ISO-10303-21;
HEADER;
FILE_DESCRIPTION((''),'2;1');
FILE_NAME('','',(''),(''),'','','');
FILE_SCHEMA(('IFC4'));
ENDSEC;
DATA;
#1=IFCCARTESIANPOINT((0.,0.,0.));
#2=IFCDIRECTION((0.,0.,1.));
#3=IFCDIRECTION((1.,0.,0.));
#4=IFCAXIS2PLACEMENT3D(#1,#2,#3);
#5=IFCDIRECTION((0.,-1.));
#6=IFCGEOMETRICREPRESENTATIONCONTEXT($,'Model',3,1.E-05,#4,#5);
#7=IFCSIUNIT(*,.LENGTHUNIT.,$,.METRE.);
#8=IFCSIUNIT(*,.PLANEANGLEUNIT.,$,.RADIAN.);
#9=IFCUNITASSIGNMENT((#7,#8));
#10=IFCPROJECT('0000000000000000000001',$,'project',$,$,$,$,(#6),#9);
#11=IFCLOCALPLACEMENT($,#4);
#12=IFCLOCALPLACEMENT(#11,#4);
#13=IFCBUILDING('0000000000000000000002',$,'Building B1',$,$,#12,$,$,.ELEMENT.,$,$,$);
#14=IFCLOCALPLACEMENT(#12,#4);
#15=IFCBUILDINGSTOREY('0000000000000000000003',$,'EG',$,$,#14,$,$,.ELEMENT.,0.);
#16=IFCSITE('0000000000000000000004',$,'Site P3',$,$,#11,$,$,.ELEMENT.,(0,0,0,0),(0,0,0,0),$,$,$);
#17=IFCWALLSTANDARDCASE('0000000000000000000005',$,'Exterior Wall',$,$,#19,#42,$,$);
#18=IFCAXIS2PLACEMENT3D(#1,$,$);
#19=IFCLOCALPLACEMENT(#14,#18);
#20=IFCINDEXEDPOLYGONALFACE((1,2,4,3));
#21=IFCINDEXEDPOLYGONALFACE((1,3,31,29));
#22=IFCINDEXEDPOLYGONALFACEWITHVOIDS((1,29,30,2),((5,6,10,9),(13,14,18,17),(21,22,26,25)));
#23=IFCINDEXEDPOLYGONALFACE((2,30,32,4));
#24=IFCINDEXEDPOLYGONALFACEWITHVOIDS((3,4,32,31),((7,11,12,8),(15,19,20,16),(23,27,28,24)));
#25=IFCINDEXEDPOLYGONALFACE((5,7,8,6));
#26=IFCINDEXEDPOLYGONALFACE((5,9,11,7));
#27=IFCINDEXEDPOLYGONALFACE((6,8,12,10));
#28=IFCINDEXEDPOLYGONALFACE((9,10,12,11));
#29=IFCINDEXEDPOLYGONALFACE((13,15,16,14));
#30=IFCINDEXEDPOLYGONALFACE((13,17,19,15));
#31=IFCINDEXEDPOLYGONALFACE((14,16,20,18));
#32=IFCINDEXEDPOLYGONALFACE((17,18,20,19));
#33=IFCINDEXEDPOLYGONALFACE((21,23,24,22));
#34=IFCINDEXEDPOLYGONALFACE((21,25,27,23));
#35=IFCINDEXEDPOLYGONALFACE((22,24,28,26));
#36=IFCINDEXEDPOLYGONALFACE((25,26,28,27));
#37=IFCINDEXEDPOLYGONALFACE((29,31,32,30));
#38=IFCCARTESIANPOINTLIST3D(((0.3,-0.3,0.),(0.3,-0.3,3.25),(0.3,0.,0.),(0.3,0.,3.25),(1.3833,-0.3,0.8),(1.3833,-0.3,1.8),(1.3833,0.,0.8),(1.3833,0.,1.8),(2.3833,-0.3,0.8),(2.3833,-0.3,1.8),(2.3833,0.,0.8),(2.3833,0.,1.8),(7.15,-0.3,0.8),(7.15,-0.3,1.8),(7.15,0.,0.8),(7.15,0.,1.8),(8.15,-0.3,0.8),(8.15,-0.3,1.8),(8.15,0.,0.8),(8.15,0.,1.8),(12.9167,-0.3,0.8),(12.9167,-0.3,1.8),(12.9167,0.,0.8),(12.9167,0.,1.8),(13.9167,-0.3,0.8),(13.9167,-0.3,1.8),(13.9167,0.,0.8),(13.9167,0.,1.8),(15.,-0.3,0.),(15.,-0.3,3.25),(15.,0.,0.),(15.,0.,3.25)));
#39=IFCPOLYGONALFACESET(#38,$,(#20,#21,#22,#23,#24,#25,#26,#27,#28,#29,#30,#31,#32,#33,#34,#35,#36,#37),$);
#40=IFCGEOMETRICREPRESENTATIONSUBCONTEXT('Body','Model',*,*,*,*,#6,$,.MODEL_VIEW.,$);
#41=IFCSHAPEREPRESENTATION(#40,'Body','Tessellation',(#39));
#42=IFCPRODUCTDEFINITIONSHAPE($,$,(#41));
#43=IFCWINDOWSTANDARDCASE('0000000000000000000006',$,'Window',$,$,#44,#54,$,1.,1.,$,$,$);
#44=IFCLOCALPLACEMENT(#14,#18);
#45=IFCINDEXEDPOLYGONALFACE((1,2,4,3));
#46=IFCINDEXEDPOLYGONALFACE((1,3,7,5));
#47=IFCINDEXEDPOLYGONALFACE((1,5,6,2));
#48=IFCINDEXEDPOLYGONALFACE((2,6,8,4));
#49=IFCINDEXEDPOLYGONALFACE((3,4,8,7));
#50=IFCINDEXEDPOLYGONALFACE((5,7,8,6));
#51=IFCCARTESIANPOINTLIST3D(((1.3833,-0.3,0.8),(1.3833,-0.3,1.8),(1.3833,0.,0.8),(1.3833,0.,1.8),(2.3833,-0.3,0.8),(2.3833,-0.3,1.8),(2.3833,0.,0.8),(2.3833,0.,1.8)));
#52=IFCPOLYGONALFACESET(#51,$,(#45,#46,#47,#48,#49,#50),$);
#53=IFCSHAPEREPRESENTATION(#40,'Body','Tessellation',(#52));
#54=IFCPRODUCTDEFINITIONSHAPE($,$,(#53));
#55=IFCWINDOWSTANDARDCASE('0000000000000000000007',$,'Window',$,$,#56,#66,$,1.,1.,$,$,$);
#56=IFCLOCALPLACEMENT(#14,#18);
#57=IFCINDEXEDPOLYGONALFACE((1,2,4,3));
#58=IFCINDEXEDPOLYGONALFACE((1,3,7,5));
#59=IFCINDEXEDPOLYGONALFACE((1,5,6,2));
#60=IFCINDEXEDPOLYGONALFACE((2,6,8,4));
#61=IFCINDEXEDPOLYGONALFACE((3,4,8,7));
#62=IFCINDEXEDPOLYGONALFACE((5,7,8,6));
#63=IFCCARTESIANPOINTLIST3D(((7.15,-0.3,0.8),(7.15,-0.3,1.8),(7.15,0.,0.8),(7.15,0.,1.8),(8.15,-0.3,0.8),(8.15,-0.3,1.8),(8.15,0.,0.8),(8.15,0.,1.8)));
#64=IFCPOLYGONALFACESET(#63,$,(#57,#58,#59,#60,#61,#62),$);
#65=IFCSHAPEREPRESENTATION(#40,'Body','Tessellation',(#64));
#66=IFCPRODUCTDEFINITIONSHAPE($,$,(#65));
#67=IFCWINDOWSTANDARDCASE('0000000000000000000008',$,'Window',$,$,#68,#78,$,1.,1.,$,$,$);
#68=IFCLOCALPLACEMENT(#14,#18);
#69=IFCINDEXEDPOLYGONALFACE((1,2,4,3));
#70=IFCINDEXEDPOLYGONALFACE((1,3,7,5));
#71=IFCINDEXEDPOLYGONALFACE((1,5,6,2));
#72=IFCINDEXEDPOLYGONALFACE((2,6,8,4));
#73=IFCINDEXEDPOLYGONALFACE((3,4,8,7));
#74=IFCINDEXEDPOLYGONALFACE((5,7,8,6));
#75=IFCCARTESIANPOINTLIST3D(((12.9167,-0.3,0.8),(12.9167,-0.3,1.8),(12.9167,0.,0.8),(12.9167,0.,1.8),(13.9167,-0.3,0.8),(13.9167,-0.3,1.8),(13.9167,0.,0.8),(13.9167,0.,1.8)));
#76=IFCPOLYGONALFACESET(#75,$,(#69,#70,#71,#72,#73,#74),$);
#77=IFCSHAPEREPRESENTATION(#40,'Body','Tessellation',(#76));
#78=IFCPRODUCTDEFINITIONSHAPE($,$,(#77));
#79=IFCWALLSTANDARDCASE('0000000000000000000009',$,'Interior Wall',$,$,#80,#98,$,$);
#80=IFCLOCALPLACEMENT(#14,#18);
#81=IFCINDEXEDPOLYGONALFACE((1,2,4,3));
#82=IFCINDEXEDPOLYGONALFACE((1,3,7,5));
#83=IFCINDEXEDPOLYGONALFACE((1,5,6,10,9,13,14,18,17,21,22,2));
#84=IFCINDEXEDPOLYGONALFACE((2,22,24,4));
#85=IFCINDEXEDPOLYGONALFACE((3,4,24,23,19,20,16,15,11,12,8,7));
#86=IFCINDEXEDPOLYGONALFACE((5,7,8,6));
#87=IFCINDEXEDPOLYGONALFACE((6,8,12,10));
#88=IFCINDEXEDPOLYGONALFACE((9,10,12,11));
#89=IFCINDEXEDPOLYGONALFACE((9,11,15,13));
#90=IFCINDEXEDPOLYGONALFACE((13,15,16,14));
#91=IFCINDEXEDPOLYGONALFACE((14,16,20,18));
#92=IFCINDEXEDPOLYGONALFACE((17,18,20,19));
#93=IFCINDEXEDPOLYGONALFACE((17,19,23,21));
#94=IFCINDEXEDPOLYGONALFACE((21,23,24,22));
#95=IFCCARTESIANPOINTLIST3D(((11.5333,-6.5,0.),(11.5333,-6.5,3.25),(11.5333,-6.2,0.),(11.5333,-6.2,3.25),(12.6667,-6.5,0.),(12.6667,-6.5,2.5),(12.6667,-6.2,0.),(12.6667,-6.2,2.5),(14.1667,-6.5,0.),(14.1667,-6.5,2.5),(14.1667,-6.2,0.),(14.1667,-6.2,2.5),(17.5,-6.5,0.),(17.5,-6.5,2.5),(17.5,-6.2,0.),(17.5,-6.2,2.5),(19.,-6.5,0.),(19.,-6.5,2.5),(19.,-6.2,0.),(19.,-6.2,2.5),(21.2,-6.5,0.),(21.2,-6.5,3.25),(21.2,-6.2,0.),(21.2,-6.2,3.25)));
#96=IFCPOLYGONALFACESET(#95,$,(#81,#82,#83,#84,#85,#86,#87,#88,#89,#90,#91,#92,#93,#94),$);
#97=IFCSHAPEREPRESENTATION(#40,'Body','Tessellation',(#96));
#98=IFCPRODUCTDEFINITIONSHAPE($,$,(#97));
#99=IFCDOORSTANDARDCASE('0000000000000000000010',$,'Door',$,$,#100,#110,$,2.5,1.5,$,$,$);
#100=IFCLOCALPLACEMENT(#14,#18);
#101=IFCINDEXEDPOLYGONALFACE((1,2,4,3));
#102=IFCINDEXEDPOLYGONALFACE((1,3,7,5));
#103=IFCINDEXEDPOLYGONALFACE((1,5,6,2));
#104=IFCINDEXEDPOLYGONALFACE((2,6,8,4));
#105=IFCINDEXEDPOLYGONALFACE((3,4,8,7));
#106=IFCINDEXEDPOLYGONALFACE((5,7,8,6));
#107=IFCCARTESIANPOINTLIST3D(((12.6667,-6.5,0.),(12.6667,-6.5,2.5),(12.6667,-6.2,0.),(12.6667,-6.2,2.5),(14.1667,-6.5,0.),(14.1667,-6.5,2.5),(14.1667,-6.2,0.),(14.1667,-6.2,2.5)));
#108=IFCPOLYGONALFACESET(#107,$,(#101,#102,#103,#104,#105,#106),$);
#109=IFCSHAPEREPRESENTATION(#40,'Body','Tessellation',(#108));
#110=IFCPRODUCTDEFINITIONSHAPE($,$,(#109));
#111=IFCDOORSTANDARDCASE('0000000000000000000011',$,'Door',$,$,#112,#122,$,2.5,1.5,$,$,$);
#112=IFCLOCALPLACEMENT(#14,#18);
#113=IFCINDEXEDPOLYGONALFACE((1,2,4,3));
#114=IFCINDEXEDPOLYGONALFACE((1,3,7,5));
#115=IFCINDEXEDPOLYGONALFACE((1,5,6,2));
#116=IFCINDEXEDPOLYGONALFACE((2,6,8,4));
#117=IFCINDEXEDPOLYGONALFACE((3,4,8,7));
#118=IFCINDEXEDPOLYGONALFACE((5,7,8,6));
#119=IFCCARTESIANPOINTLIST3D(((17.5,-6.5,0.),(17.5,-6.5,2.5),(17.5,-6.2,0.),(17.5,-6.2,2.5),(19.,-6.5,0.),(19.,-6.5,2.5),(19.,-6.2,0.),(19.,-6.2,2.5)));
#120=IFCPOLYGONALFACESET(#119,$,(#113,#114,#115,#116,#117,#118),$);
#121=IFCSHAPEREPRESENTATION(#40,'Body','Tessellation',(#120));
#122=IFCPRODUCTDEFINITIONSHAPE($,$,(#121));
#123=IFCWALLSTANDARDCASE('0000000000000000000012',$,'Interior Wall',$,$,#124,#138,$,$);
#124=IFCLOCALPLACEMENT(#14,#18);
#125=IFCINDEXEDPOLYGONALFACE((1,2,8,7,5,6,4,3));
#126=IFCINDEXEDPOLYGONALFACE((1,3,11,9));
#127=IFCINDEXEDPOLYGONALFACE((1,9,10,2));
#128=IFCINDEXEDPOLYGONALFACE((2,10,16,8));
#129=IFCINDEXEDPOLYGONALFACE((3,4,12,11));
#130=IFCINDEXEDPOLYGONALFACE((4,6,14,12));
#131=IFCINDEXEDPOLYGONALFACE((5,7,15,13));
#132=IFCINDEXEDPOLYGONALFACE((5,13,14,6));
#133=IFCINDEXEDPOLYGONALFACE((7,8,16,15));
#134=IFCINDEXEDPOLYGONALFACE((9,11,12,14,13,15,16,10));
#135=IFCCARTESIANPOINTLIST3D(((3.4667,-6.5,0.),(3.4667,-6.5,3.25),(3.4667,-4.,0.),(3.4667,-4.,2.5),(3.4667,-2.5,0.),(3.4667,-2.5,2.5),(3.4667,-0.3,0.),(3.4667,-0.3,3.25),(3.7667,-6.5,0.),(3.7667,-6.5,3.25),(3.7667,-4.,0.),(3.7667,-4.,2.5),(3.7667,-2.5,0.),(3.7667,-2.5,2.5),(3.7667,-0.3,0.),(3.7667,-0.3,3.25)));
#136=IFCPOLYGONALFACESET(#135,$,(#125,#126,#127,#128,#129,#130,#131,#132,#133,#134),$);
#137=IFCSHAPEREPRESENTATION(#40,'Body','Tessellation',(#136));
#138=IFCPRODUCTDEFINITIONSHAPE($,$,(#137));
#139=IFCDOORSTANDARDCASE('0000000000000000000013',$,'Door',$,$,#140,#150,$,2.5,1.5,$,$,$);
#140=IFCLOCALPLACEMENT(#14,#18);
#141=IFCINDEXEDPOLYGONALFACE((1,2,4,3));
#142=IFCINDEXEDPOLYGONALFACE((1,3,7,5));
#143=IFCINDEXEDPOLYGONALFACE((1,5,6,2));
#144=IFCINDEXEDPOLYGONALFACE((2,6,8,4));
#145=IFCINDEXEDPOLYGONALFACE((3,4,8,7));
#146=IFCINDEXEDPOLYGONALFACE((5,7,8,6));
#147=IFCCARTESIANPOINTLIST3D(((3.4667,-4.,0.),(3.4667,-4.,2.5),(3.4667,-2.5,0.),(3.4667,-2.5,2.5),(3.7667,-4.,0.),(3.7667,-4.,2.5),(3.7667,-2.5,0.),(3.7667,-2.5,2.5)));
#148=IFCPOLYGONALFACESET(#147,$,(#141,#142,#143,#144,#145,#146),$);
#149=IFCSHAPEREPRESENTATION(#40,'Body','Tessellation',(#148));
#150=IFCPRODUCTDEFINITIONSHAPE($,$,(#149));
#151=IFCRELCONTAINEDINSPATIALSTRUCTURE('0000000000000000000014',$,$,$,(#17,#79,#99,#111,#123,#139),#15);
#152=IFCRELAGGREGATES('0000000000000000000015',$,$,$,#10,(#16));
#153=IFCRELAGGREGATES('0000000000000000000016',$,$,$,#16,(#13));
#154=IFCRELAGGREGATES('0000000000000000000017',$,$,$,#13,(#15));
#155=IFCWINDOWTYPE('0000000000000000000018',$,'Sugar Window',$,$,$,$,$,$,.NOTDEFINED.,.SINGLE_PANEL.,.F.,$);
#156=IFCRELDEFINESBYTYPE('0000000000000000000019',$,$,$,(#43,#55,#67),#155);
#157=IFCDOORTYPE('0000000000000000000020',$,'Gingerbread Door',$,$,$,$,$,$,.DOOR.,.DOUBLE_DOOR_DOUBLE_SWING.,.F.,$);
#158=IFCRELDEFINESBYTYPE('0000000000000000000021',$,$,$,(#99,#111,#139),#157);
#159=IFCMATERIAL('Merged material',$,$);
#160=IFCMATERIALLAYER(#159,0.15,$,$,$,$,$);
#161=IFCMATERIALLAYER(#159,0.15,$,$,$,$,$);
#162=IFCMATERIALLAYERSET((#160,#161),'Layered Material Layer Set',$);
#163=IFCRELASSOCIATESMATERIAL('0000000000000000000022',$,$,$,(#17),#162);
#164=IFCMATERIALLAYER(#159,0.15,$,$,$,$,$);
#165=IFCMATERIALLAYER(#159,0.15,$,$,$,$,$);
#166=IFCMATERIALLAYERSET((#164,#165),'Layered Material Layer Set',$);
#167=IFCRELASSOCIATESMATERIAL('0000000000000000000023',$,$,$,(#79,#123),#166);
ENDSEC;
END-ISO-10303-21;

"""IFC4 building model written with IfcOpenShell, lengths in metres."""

from ifc_helpers import new_model, si_unit, direction, frame, origin_with_axes, place, context, subcontext, project, spatial, polyline, outline, extrude, source, transform, mapped, material, layer, layer_set, layer_usage, type_object, element, fill, save


model = new_model("IFC4")

# Units and contexts
model_context = context("Model", 3, precision=1e-05, world=origin_with_axes(), true_north=direction((0.0, -1.0)))
body_context = subcontext(model_context, "Body", "Model", "MODEL_VIEW")
ifc_project = project(units=[si_unit("LENGTHUNIT", "METRE"), si_unit("PLANEANGLEUNIT", "RADIAN")], contexts=[model_context])

# Site, building, storey
site_placement = place(None, origin_with_axes())
site = spatial("IfcSite", under=ifc_project, at=site_placement, Name="Site P3", CompositionType="ELEMENT", RefLatitude=(0, 0, 0, 0), RefLongitude=(0, 0, 0, 0))
building_placement = place(site_placement, origin_with_axes())
building = spatial("IfcBuilding", under=site, at=building_placement, Name="Building B1", CompositionType="ELEMENT")
storey_placement = place(building_placement, origin_with_axes())
storey = spatial("IfcBuildingStorey", under=building, at=storey_placement, Name="EG", CompositionType="ELEMENT", Elevation=0.0)

# Shared definitions
ifc_material = material(Name="Merged material")

# Shared definitions
ifc_layer_1 = layer(ifc_material, 0.15)
ifc_layer_2 = layer(ifc_material, 0.15)
ifc_layer_set_1 = layer_set([ifc_layer_1, ifc_layer_2], Name="Layered Material Layer Set")
ifc_layer_usage_1 = layer_usage(ifc_layer_set_1, "AXIS2", "POSITIVE", -0.15)
window_type = type_object("IfcWindowType", Name="Sugar Window", ParameterTakesPrecedence=False, PartitioningType="SINGLE_PANEL", PredefinedType="NOTDEFINED")

# Shared definitions
shared_shape_1 = source(origin_with_axes(), body_context, "Body", "SweptSolid", [
    extrude(outline(polyline([(0.0, 0.0), (0.0, 1.0), (1.0, 1.0), (1.0, 0.0), (0.0, 0.0)])), frame((0.0, -0.15, 0.0), z_axis=(0.0, 1.0, 0.0), x_axis=(0.0, 0.0, 1.0)), (0.0, 0.0, 1.0), 0.3),
])

# Wall, openings, windows
wall_1_placement = place(storey_placement, frame((15.0, -0.15, 0.0), z_axis=(0.0, 0.0, 1.0), x_axis=(-1.0, 0.0, 0.0)))
wall_1 = element("IfcWallStandardCase", 1, at=wall_1_placement, inside=storey, material=ifc_layer_usage_1, Name="Exterior Wall", context=body_context, shape_type="SweptSolid", body=[
    extrude(outline(polyline([(0.0, 0.15), (14.7, 0.15), (14.7, -0.15), (0.0, -0.15), (0.0, 0.15)])), origin_with_axes(), (0.0, 0.0, 1.0), 3.25),
])
opening_1_placement = place(wall_1_placement, frame((12.6167, 0.0, 0.8), z_axis=(0.0, 0.0, 1.0), x_axis=(1.0, 0.0, 0.0)))
opening_1 = element("IfcOpeningStandardCase", 2, at=opening_1_placement, cuts=wall_1, context=body_context, shape_type="SweptSolid", body=[
    extrude(outline(polyline([(0.0, 0.0), (0.0, 1.0), (1.0, 1.0), (1.0, 0.0), (0.0, 0.0)])), frame((0.0, -0.15, 0.0), z_axis=(0.0, 1.0, 0.0), x_axis=(0.0, 0.0, 1.0)), (0.0, 0.0, 1.0), 0.3),
])
opening_2_placement = place(wall_1_placement, frame((6.85, 0.0, 0.8), z_axis=(0.0, 0.0, 1.0), x_axis=(1.0, 0.0, 0.0)))
opening_2 = element("IfcOpeningStandardCase", 3, at=opening_2_placement, cuts=wall_1, context=body_context, shape_type="SweptSolid", body=[
    extrude(outline(polyline([(0.0, 0.0), (0.0, 1.0), (1.0, 1.0), (1.0, 0.0), (0.0, 0.0)])), frame((0.0, -0.15, 0.0), z_axis=(0.0, 1.0, 0.0), x_axis=(0.0, 0.0, 1.0)), (0.0, 0.0, 1.0), 0.3),
])
opening_3_placement = place(wall_1_placement, frame((1.0833, 0.0, 0.8), z_axis=(0.0, 0.0, 1.0), x_axis=(1.0, 0.0, 0.0)))
opening_3 = element("IfcOpeningStandardCase", 4, at=opening_3_placement, cuts=wall_1, context=body_context, shape_type="SweptSolid", body=[
    extrude(outline(polyline([(0.0, 0.0), (0.0, 1.0), (1.0, 1.0), (1.0, 0.0), (0.0, 0.0)])), frame((0.0, -0.15, 0.0), z_axis=(0.0, 1.0, 0.0), x_axis=(0.0, 0.0, 1.0)), (0.0, 0.0, 1.0), 0.3),
])
window_1_placement = place(opening_1_placement, origin_with_axes())
window_1 = element("IfcWindowStandardCase", 5, at=window_1_placement, type_object=window_type, Name="Window", OverallHeight=1.0, OverallWidth=1.0, context=body_context, shape_type="MappedRepresentation", body=[
    mapped(shared_shape_1, transform((0.0, 0.0, 0.0))),
])
fill(opening_1, window_1)
window_2_placement = place(opening_2_placement, origin_with_axes())
window_2 = element("IfcWindowStandardCase", 6, at=window_2_placement, type_object=window_type, Name="Window", OverallHeight=1.0, OverallWidth=1.0, context=body_context, shape_type="MappedRepresentation", body=[
    mapped(shared_shape_1, transform((0.0, 0.0, 0.0))),
])
fill(opening_2, window_2)
window_3_placement = place(opening_3_placement, origin_with_axes())
window_3 = element("IfcWindowStandardCase", 7, at=window_3_placement, type_object=window_type, Name="Window", OverallHeight=1.0, OverallWidth=1.0, context=body_context, shape_type="MappedRepresentation", body=[
    mapped(shared_shape_1, transform((0.0, 0.0, 0.0))),
])
fill(opening_3, window_3)

# Wall, openings, doors
ifc_layer_3 = layer(ifc_material, 0.15)
ifc_layer_4 = layer(ifc_material, 0.15)
ifc_layer_set_2 = layer_set([ifc_layer_3, ifc_layer_4], Name="Layered Material Layer Set")
ifc_layer_usage_2 = layer_usage(ifc_layer_set_2, "AXIS2", "POSITIVE", -0.15)
wall_2_placement = place(storey_placement, frame((11.5333, -6.35, 0.0), z_axis=(0.0, 0.0, 1.0), x_axis=(1.0, 0.0, 0.0)))
wall_2 = element("IfcWallStandardCase", 8, at=wall_2_placement, inside=storey, material=ifc_layer_usage_2, Name="Interior Wall", context=body_context, shape_type="SweptSolid", body=[
    extrude(outline(polyline([(0.0, 0.15), (9.6667, 0.15), (9.6667, -0.15), (0.0, -0.15), (0.0, 0.15)])), origin_with_axes(), (0.0, 0.0, 1.0), 3.25),
])
opening_4_placement = place(wall_2_placement, frame((1.1333, 0.0, 0.0), z_axis=(0.0, 0.0, 1.0), x_axis=(1.0, 0.0, 0.0)))
opening_4 = element("IfcOpeningStandardCase", 9, at=opening_4_placement, cuts=wall_2, context=body_context, shape_type="SweptSolid", body=[
    extrude(outline(polyline([(0.0, 0.0), (0.0, 1.5), (2.5, 1.5), (2.5, 0.0), (0.0, 0.0)])), frame((0.0, -0.15, 0.0), z_axis=(0.0, 1.0, 0.0), x_axis=(0.0, 0.0, 1.0)), (0.0, 0.0, 1.0), 0.3),
])
opening_5_placement = place(wall_2_placement, frame((5.9667, 0.0, 0.0), z_axis=(0.0, 0.0, 1.0), x_axis=(1.0, 0.0, 0.0)))
opening_5 = element("IfcOpeningStandardCase", 10, at=opening_5_placement, cuts=wall_2, context=body_context, shape_type="SweptSolid", body=[
    extrude(outline(polyline([(0.0, 0.0), (0.0, 1.5), (2.5, 1.5), (2.5, 0.0), (0.0, 0.0)])), frame((0.0, -0.15, 0.0), z_axis=(0.0, 1.0, 0.0), x_axis=(0.0, 0.0, 1.0)), (0.0, 0.0, 1.0), 0.3),
])
door_type = type_object("IfcDoorType", Name="Gingerbread Door", OperationType="DOUBLE_DOOR_DOUBLE_SWING", ParameterTakesPrecedence=False, PredefinedType="DOOR")
shared_shape_2 = source(origin_with_axes(), body_context, "Body", "SweptSolid", [
    extrude(outline(polyline([(0.0, 0.0), (0.0, 1.5), (2.5, 1.5), (2.5, 0.0), (0.0, 0.0)])), frame((0.0, -0.15, 0.0), z_axis=(0.0, 1.0, 0.0), x_axis=(0.0, 0.0, 1.0)), (0.0, 0.0, 1.0), 0.3),
])
door_1_placement = place(opening_4_placement, origin_with_axes())
door_1 = element("IfcDoorStandardCase", 11, at=door_1_placement, inside=storey, type_object=door_type, Name="Door", OverallHeight=2.5, OverallWidth=1.5, context=body_context, shape_type="MappedRepresentation", body=[
    mapped(shared_shape_2, transform((0.0, 0.0, 0.0))),
])
fill(opening_4, door_1)
door_2_placement = place(opening_5_placement, origin_with_axes())
door_2 = element("IfcDoorStandardCase", 12, at=door_2_placement, inside=storey, type_object=door_type, Name="Door", OverallHeight=2.5, OverallWidth=1.5, context=body_context, shape_type="MappedRepresentation", body=[
    mapped(shared_shape_2, transform((0.0, 0.0, 0.0))),
])
fill(opening_5, door_2)

# Wall, opening, door
wall_3_placement = place(storey_placement, frame((3.6167, -0.3, 0.0), z_axis=(0.0, 0.0, 1.0), x_axis=(0.0, -1.0, 0.0)))
wall_3 = element("IfcWallStandardCase", 13, at=wall_3_placement, inside=storey, material=ifc_layer_usage_2, Name="Interior Wall", context=body_context, shape_type="SweptSolid", body=[
    extrude(outline(polyline([(0.0, 0.15), (6.2, 0.15), (6.2, -0.15), (0.0, -0.15), (0.0, 0.15)])), origin_with_axes(), (0.0, 0.0, 1.0), 3.25),
])
opening_6_placement = place(wall_3_placement, frame((2.2, 0.0, 0.0), z_axis=(0.0, 0.0, 1.0), x_axis=(1.0, 0.0, 0.0)))
opening_6 = element("IfcOpeningStandardCase", 14, at=opening_6_placement, cuts=wall_3, context=body_context, shape_type="SweptSolid", body=[
    extrude(outline(polyline([(0.0, 0.0), (0.0, 1.5), (2.5, 1.5), (2.5, 0.0), (0.0, 0.0)])), frame((0.0, -0.15, 0.0), z_axis=(0.0, 1.0, 0.0), x_axis=(0.0, 0.0, 1.0)), (0.0, 0.0, 1.0), 0.3),
])
door_3_placement = place(opening_6_placement, origin_with_axes())
door_3 = element("IfcDoorStandardCase", 15, at=door_3_placement, inside=storey, type_object=door_type, Name="Door", OverallHeight=2.5, OverallWidth=1.5, context=body_context, shape_type="MappedRepresentation", body=[
    mapped(shared_shape_2, transform((0.0, 0.0, 0.0))),
])
fill(opening_6, door_3)

save(model, "model.ifc")
